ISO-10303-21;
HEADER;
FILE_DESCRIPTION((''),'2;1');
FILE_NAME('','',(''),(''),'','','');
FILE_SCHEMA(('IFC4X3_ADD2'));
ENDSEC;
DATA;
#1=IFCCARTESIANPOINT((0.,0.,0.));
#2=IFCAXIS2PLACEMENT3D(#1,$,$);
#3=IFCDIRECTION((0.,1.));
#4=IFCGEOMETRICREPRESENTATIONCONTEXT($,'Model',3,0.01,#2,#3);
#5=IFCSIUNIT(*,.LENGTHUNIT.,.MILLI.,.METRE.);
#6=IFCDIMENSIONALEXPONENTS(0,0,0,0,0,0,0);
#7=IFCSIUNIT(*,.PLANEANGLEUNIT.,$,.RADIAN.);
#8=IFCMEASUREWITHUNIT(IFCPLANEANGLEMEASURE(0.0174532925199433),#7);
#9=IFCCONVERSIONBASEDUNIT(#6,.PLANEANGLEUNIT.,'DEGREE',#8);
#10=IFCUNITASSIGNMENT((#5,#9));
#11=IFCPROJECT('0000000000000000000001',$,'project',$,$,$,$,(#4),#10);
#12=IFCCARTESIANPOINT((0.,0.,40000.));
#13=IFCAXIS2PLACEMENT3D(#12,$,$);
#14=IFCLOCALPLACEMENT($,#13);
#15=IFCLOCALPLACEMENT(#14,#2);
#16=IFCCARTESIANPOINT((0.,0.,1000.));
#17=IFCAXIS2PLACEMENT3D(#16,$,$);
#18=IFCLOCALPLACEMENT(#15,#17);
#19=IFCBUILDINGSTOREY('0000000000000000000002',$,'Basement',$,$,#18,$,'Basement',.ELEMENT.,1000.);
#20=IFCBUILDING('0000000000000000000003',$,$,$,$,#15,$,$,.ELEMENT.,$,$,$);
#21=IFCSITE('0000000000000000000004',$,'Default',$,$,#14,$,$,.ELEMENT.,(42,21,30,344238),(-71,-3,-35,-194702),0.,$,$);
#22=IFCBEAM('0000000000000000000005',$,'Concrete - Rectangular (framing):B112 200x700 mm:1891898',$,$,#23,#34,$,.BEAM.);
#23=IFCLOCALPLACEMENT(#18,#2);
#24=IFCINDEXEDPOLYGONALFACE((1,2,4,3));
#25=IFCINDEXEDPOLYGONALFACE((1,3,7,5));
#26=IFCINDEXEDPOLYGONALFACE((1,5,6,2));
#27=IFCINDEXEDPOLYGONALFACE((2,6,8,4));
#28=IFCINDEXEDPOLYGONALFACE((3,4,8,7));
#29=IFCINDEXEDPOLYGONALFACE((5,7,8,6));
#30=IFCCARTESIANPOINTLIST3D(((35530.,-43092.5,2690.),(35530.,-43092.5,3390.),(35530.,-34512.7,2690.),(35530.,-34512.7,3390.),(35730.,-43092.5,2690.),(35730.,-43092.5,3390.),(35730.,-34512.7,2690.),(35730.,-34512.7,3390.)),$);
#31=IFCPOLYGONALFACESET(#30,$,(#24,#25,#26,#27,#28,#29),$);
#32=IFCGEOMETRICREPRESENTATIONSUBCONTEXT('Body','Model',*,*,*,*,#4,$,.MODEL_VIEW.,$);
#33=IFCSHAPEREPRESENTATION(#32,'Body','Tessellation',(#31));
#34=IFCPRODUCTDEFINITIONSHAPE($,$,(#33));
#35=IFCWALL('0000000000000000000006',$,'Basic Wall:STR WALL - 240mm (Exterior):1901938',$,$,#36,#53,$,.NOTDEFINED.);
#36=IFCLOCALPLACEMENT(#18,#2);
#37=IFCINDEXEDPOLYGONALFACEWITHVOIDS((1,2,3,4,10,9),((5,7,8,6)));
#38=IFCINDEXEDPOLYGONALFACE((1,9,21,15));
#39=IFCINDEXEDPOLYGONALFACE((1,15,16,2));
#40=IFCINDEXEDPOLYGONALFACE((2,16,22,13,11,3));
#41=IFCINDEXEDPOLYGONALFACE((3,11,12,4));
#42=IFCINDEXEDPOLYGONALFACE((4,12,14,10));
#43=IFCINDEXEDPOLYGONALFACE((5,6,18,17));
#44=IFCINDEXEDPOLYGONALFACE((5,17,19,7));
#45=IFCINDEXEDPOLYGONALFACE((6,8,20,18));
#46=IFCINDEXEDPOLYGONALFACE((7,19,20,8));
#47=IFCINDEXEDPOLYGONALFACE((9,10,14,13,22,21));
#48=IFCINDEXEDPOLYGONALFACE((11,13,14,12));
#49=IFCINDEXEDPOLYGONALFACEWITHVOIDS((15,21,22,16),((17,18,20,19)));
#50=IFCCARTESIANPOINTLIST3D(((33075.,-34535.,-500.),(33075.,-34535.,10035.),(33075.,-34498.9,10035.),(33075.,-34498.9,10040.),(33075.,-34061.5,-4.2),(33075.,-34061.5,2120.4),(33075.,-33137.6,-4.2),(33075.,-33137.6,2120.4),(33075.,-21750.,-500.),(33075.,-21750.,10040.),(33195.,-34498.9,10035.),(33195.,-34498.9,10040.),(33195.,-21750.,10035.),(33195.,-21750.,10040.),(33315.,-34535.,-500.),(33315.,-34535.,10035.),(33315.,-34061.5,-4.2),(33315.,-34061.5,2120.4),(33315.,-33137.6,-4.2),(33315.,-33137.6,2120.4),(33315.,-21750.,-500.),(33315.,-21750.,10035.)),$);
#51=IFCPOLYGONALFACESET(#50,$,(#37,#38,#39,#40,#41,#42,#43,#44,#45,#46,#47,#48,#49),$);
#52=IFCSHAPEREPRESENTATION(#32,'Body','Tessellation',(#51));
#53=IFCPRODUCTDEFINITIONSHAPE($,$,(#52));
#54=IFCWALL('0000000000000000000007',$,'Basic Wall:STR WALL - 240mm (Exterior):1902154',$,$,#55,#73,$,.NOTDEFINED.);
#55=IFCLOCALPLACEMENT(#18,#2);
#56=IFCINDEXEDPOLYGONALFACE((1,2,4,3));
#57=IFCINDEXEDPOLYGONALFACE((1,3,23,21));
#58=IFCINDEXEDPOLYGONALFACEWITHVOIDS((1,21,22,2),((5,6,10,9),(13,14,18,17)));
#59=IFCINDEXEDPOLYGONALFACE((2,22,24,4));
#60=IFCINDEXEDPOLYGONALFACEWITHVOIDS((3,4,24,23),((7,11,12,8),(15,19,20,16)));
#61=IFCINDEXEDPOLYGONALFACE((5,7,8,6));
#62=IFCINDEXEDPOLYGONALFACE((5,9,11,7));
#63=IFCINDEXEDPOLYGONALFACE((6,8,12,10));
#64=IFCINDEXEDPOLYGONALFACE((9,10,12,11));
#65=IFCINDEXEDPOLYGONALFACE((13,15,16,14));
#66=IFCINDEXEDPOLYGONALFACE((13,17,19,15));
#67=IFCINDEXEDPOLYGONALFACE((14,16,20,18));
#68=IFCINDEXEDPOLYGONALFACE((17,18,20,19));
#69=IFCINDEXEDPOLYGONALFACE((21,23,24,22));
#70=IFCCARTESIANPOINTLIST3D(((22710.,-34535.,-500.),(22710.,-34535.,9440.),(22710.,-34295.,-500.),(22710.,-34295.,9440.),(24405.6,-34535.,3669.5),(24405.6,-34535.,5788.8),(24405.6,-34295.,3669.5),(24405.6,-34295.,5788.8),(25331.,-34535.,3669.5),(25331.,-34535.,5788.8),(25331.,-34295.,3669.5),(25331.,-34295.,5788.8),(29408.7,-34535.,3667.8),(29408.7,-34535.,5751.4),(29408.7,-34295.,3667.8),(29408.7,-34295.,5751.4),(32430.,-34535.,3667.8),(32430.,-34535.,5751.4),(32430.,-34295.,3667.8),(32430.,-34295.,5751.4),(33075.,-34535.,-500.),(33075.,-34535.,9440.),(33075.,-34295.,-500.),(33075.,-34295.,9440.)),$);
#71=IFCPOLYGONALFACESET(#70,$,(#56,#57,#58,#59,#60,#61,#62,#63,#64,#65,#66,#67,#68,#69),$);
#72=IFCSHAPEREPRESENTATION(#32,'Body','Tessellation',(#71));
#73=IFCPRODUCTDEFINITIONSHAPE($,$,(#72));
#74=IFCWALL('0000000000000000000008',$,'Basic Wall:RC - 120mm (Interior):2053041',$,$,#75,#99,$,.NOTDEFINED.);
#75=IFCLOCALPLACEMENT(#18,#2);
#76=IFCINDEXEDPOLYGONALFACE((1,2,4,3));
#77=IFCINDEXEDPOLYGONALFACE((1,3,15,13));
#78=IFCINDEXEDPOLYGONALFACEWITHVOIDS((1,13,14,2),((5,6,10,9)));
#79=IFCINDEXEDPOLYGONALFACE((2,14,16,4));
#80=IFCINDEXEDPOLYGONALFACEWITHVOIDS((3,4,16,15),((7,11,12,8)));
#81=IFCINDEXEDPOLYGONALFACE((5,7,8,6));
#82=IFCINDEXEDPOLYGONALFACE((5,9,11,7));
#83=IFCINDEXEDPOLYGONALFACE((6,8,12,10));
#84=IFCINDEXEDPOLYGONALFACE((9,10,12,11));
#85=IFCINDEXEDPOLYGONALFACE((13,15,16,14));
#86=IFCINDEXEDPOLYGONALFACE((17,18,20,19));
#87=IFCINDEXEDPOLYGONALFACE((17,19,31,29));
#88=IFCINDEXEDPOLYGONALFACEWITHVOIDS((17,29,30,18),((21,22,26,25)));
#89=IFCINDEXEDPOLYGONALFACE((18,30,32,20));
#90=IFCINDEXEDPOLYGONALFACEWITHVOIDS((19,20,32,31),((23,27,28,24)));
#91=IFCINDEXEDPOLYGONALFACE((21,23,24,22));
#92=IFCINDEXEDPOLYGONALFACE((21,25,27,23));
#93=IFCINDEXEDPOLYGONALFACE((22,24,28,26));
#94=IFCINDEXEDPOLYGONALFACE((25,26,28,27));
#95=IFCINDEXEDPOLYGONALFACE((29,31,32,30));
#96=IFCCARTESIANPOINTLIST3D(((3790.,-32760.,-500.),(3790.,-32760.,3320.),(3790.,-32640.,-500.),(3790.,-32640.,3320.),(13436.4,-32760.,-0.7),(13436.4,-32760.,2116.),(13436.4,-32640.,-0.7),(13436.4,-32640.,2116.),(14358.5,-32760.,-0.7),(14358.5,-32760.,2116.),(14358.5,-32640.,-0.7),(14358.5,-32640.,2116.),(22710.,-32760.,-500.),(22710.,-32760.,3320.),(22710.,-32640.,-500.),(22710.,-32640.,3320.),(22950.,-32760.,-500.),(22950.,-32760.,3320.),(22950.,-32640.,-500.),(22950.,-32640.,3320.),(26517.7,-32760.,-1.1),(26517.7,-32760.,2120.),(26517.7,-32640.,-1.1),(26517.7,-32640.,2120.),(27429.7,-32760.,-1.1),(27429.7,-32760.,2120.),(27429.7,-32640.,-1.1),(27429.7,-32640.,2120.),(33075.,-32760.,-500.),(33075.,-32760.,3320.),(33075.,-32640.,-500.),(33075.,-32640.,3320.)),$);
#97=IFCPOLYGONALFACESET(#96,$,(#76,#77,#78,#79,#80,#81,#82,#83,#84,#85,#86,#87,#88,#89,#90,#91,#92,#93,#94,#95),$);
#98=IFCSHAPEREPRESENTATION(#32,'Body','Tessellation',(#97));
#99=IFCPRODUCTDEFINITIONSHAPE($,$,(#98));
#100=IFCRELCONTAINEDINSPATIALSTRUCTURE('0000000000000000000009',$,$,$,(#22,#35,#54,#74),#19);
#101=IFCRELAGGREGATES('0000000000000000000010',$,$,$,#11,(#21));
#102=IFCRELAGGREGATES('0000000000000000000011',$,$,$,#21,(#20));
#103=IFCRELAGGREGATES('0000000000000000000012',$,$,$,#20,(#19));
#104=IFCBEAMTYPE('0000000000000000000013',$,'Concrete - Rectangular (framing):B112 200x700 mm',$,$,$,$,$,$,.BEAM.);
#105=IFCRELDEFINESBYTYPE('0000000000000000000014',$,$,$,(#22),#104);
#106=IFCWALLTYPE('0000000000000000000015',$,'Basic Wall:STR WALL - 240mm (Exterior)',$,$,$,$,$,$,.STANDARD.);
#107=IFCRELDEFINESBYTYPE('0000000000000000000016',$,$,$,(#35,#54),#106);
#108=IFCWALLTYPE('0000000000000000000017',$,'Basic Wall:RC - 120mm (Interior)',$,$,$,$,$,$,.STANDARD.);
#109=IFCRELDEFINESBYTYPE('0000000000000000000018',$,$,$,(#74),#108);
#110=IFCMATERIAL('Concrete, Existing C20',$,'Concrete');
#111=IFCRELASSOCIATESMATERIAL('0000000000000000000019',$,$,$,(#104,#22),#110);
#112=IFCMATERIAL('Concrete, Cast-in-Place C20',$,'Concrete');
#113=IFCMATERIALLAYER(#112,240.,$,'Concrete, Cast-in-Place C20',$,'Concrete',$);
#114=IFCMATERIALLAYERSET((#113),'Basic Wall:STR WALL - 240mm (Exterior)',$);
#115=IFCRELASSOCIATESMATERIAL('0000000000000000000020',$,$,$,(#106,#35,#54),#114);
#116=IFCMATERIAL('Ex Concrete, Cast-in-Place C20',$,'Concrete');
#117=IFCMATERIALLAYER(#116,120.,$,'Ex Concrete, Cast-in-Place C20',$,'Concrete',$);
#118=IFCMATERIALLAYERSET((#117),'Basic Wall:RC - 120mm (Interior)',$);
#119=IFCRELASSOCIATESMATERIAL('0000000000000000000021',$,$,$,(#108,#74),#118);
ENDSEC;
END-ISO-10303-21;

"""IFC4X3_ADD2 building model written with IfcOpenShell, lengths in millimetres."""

from ifc_helpers import new_model, entity, si_unit, converted_unit, direction, frame, frame_2d, origin, origin_2d_with_axis, place, context, subcontext, project, spatial, polyline, rectangle, extrude, clip, bounded_halfspace, source, transform, mapped, material, layer, layer_set, material_profile, profile_set, profile_usage, type_object, type_shapes, element, save


model = new_model("IFC4X3_ADD2")

# Units and contexts
model_context = context("Model", 3, precision=0.01, world=origin(), true_north=direction((0.0, 1.0)))
body_context = subcontext(model_context, "Body", "Model", "MODEL_VIEW")
ifc_project = project(units=[si_unit("LENGTHUNIT", "METRE", prefix="MILLI"), converted_unit("PLANEANGLEUNIT", "DEGREE", entity("IfcPlaneAngleMeasure", 0.0174532925199433), si_unit("PLANEANGLEUNIT", "RADIAN"), dimensions=[0, 0, 0, 0, 0, 0, 0])], contexts=[model_context])

# Site, building, storey
site_placement = place(None, frame((0.0, 0.0, 40000.0)))
site = spatial("IfcSite", under=ifc_project, at=site_placement, Name="Default", CompositionType="ELEMENT", RefLatitude=(42, 21, 30, 344238), RefLongitude=(-71, -3, -35, -194702), RefElevation=0.0)
building_placement = place(site_placement, origin())
building = spatial("IfcBuilding", under=site, at=building_placement, CompositionType="ELEMENT")
storey_placement = place(building_placement, frame((0.0, 0.0, 1000.0)))
storey = spatial("IfcBuildingStorey", under=building, at=storey_placement, Name="Basement", LongName="Basement", CompositionType="ELEMENT", Elevation=1000.0)

# Shared definitions
ifc_material_1 = material(Name="Concrete, Existing C20", Category="Concrete")

# Beam
ifc_material_profile_1 = material_profile(ifc_material_1, rectangle(XDim=8579.8, YDim=200.0, at=origin_2d_with_axis()), Name="B112 200x700 mm")
ifc_profile_set_1 = profile_set([ifc_material_profile_1], Name="B112 200x700 mm")
ifc_profile_usage_1 = profile_usage(ifc_profile_set_1, cardinal=8)
beam_type_1 = type_object("IfcBeamType", Name="Concrete - Rectangular (framing):B112 200x700 mm", PredefinedType="BEAM", material=ifc_profile_set_1)
shared_shape_1 = source(origin(), body_context, "Body", "SweptSolid", [
    extrude(rectangle(XDim=8579.8, YDim=200.0, at=origin_2d_with_axis()), frame((72.6, 0.0, -350.0), z_axis=(0.0, 0.0, 1.0), x_axis=(-1.0, 0.0, 0.0)), (0.0, 0.0, 1.0), 700.0),
])
type_shapes(beam_type_1, [shared_shape_1])
for number, where, z_axis, x_axis, name in (
    (1, (35630.0, -38730.0, 3040.0), (0.0, 0.0, 1.0), (0.0, -1.0, 0.0), "Concrete - Rectangular (framing):B112 200x700 mm:1891898"),
):
    element("IfcBeam", number, at=place(storey_placement, frame(where, z_axis=z_axis, x_axis=x_axis)), inside=storey, type_object=beam_type_1, material=ifc_profile_usage_1, Name=name, PredefinedType="BEAM", context=body_context, shape_type="MappedRepresentation", body=[
        mapped(shared_shape_1, transform((0.0, 0.0, 0.0), scale=1.0)),
    ])

# Wall, opening
ifc_material_2 = material(Name="Concrete, Cast-in-Place C20", Category="Concrete")
ifc_layer_1 = layer(ifc_material_2, 240.0, Name="Concrete, Cast-in-Place C20", Category="Concrete")
ifc_layer_set_1 = layer_set([ifc_layer_1], Name="Basic Wall:STR WALL - 240mm (Exterior)")
wall_type_1 = type_object("IfcWallType", Name="Basic Wall:STR WALL - 240mm (Exterior)", PredefinedType="STANDARD", material=ifc_layer_set_1)
wall_1_placement = place(storey_placement, frame((33195.0, -21750.0, -500.0), z_axis=(0.0, 0.0, 1.0), x_axis=(0.0, -1.0, 0.0)))
wall_1 = element("IfcWall", 2, at=wall_1_placement, inside=storey, type_object=wall_type_1, material=ifc_layer_set_1, Name="Basic Wall:STR WALL - 240mm (Exterior):1901938", PredefinedType="NOTDEFINED", context=body_context, shape_type="Clipping", body=[
    clip(clip(clip(clip(extrude(rectangle(XDim=12785.0, YDim=240.0, at=frame_2d((6392.5, 0.0), x_axis=(-1.0, 0.0))), origin(), (0.0, 0.0, 1.0), 10540.0), bounded_halfspace(frame((0.0, -120.0, 10540.0), z_axis=(0.0, 0.0, -1.0), x_axis=(1.0, 0.0, 0.0)), True, frame((0.0, -120.0, 10540.0)), polyline([(0.0, 0.0), (12748.9, 0.0), (12748.9, 120.0), (0.0, 120.0), (0.0, 0.0)]))), bounded_halfspace(frame((12748.9, -120.0, 10535.0), z_axis=(0.0, 0.0, 1.0), x_axis=(0.0, 1.0, 0.0)), False, frame((12748.9, -120.0, 10535.0)), polyline([(0.0, 0.0), (36.1, 0.0), (36.1, 120.0), (0.0, 120.0), (0.0, 0.0)]))), bounded_halfspace(frame((12748.9, 120.0, 10535.0), z_axis=(0.0, 0.0, 1.0), x_axis=(0.0, 1.0, 0.0)), False, frame((12748.9, 120.0, 10535.0)), polyline([(0.0, 0.0), (-12748.9, 0.0), (-12748.9, -120.0), (0.0, -120.0), (0.0, 0.0)]))), bounded_halfspace(frame((12785.0, 0.0, 10535.0), z_axis=(0.0, 0.0, 1.0), x_axis=(0.0, 1.0, 0.0)), False, frame((12785.0, 0.0, 10535.0)), polyline([(0.0, 0.0), (0.0, 120.0), (-36.1, 120.0), (-36.1, 0.0), (0.0, 0.0)]))),
])
opening_1_placement = place(wall_1_placement, frame((12311.5, -120.0, 495.8)))
element("IfcOpeningElement", 3, at=opening_1_placement, cuts=wall_1, PredefinedType="OPENING", context=body_context, shape_type="SweptSolid", body=[
    extrude(rectangle(XDim=2124.6, YDim=923.9, at=frame_2d((0.0, 0.0), x_axis=(1.0, 0.0))), frame((-461.9, 0.0, 1062.3), z_axis=(0.0, 1.0, 0.0), x_axis=(0.0, 0.0, -1.0)), (0.0, 0.0, 1.0), 240.0),
])

# Walls, openings
wall_2_placement = place(storey_placement, frame((33075.0, -34415.0, -500.0), z_axis=(0.0, 0.0, 1.0), x_axis=(-1.0, 0.0, 0.0)))
wall_2 = element("IfcWall", 4, at=wall_2_placement, inside=storey, type_object=wall_type_1, material=ifc_layer_set_1, Name="Basic Wall:STR WALL - 240mm (Exterior):1902154", PredefinedType="NOTDEFINED", context=body_context, shape_type="SweptSolid", body=[
    extrude(rectangle(XDim=10365.0, YDim=240.0, at=frame_2d((5182.5, 0.0), x_axis=(-1.0, 0.0))), origin(), (0.0, 0.0, 1.0), 9940.0),
])
opening_2_placement = place(wall_2_placement, frame((8669.4, 120.0, 4169.5)))
element("IfcOpeningElement", 5, at=opening_2_placement, cuts=wall_2, PredefinedType="OPENING", context=body_context, shape_type="SweptSolid", body=[
    extrude(rectangle(XDim=2119.3, YDim=925.4, at=origin_2d_with_axis()), frame((-462.7, -240.0, 1059.6), z_axis=(0.0, 1.0, 0.0), x_axis=(0.0, 0.0, -1.0)), (0.0, 0.0, 1.0), 240.0),
])
opening_3_placement = place(wall_2_placement, frame((3666.3, 120.0, 4167.8)))
element("IfcOpeningElement", 6, at=opening_3_placement, cuts=wall_2, PredefinedType="OPENING", context=body_context, shape_type="SweptSolid", body=[
    extrude(rectangle(XDim=2083.6, YDim=3021.3, at=frame_2d((0.0, 0.0), x_axis=(1.0, 0.0))), frame((-1510.7, -240.0, 1041.8), z_axis=(0.0, 1.0, 0.0), x_axis=(0.0, 0.0, -1.0)), (0.0, 0.0, 1.0), 240.0),
])
ifc_material_3 = material(Name="Ex Concrete, Cast-in-Place C20", Category="Concrete")
ifc_layer_2 = layer(ifc_material_3, 120.0, Name="Ex Concrete, Cast-in-Place C20", Category="Concrete")
ifc_layer_set_2 = layer_set([ifc_layer_2], Name="Basic Wall:RC - 120mm (Interior)")
wall_type_2 = type_object("IfcWallType", Name="Basic Wall:RC - 120mm (Interior)", PredefinedType="STANDARD", material=ifc_layer_set_2)
wall_3_placement = place(storey_placement, frame((33075.0, -32700.0, -500.0), z_axis=(0.0, 0.0, 1.0), x_axis=(-1.0, 0.0, 0.0)))
wall_3 = element("IfcWall", 7, at=wall_3_placement, inside=storey, type_object=wall_type_2, material=ifc_layer_set_2, Name="Basic Wall:RC - 120mm (Interior):2053041", PredefinedType="NOTDEFINED", context=body_context, shape_type="SweptSolid", body=[
    extrude(rectangle(XDim=120.0, YDim=29285.0, at=frame_2d((14642.5, 0.0), x_axis=(0.0, -1.0))), origin(), (0.0, 0.0, 1.0), 3820.0),
])
opening_4_placement = place(storey_placement, frame((33075.0, -32700.0, -500.0), z_axis=(0.0, 0.0, 1.0), x_axis=(-1.0, 0.0, 0.0)))
element("IfcOpeningElement", 8, at=opening_4_placement, cuts=wall_3, PredefinedType="OPENING", context=body_context, shape_type="SweptSolid", body=[
    extrude(rectangle(XDim=3820.0, YDim=120.0, at=frame_2d((0.0, 0.0), x_axis=(1.0, 0.0))), frame((10365.0, 0.0, 1910.0), z_axis=(-1.0, 0.0, 0.0), x_axis=(0.0, 0.0, 1.0)), (0.0, 0.0, 1.0), 240.0),
])
opening_5_placement = place(wall_3_placement, frame((19638.6, 60.0, 499.3)))
element("IfcOpeningElement", 9, at=opening_5_placement, cuts=wall_3, PredefinedType="OPENING", context=body_context, shape_type="SweptSolid", body=[
    extrude(rectangle(XDim=2116.7, YDim=922.0, at=frame_2d((0.0, 0.0), x_axis=(1.0, 0.0))), frame((-461.0, -120.0, 1058.4), z_axis=(0.0, 1.0, 0.0), x_axis=(0.0, 0.0, -1.0)), (0.0, 0.0, 1.0), 120.0),
])
opening_6_placement = place(wall_3_placement, frame((6557.3, 60.0, 498.9)))
element("IfcOpeningElement", 10, at=opening_6_placement, cuts=wall_3, PredefinedType="OPENING", context=body_context, shape_type="SweptSolid", body=[
    extrude(rectangle(XDim=2121.1, YDim=912.0, at=frame_2d((0.0, 0.0), x_axis=(1.0, 0.0))), frame((-456.0, -120.0, 1060.6), z_axis=(0.0, 1.0, 0.0), x_axis=(0.0, 0.0, -1.0)), (0.0, 0.0, 1.0), 120.0),
])

save(model, "model.ifc")
